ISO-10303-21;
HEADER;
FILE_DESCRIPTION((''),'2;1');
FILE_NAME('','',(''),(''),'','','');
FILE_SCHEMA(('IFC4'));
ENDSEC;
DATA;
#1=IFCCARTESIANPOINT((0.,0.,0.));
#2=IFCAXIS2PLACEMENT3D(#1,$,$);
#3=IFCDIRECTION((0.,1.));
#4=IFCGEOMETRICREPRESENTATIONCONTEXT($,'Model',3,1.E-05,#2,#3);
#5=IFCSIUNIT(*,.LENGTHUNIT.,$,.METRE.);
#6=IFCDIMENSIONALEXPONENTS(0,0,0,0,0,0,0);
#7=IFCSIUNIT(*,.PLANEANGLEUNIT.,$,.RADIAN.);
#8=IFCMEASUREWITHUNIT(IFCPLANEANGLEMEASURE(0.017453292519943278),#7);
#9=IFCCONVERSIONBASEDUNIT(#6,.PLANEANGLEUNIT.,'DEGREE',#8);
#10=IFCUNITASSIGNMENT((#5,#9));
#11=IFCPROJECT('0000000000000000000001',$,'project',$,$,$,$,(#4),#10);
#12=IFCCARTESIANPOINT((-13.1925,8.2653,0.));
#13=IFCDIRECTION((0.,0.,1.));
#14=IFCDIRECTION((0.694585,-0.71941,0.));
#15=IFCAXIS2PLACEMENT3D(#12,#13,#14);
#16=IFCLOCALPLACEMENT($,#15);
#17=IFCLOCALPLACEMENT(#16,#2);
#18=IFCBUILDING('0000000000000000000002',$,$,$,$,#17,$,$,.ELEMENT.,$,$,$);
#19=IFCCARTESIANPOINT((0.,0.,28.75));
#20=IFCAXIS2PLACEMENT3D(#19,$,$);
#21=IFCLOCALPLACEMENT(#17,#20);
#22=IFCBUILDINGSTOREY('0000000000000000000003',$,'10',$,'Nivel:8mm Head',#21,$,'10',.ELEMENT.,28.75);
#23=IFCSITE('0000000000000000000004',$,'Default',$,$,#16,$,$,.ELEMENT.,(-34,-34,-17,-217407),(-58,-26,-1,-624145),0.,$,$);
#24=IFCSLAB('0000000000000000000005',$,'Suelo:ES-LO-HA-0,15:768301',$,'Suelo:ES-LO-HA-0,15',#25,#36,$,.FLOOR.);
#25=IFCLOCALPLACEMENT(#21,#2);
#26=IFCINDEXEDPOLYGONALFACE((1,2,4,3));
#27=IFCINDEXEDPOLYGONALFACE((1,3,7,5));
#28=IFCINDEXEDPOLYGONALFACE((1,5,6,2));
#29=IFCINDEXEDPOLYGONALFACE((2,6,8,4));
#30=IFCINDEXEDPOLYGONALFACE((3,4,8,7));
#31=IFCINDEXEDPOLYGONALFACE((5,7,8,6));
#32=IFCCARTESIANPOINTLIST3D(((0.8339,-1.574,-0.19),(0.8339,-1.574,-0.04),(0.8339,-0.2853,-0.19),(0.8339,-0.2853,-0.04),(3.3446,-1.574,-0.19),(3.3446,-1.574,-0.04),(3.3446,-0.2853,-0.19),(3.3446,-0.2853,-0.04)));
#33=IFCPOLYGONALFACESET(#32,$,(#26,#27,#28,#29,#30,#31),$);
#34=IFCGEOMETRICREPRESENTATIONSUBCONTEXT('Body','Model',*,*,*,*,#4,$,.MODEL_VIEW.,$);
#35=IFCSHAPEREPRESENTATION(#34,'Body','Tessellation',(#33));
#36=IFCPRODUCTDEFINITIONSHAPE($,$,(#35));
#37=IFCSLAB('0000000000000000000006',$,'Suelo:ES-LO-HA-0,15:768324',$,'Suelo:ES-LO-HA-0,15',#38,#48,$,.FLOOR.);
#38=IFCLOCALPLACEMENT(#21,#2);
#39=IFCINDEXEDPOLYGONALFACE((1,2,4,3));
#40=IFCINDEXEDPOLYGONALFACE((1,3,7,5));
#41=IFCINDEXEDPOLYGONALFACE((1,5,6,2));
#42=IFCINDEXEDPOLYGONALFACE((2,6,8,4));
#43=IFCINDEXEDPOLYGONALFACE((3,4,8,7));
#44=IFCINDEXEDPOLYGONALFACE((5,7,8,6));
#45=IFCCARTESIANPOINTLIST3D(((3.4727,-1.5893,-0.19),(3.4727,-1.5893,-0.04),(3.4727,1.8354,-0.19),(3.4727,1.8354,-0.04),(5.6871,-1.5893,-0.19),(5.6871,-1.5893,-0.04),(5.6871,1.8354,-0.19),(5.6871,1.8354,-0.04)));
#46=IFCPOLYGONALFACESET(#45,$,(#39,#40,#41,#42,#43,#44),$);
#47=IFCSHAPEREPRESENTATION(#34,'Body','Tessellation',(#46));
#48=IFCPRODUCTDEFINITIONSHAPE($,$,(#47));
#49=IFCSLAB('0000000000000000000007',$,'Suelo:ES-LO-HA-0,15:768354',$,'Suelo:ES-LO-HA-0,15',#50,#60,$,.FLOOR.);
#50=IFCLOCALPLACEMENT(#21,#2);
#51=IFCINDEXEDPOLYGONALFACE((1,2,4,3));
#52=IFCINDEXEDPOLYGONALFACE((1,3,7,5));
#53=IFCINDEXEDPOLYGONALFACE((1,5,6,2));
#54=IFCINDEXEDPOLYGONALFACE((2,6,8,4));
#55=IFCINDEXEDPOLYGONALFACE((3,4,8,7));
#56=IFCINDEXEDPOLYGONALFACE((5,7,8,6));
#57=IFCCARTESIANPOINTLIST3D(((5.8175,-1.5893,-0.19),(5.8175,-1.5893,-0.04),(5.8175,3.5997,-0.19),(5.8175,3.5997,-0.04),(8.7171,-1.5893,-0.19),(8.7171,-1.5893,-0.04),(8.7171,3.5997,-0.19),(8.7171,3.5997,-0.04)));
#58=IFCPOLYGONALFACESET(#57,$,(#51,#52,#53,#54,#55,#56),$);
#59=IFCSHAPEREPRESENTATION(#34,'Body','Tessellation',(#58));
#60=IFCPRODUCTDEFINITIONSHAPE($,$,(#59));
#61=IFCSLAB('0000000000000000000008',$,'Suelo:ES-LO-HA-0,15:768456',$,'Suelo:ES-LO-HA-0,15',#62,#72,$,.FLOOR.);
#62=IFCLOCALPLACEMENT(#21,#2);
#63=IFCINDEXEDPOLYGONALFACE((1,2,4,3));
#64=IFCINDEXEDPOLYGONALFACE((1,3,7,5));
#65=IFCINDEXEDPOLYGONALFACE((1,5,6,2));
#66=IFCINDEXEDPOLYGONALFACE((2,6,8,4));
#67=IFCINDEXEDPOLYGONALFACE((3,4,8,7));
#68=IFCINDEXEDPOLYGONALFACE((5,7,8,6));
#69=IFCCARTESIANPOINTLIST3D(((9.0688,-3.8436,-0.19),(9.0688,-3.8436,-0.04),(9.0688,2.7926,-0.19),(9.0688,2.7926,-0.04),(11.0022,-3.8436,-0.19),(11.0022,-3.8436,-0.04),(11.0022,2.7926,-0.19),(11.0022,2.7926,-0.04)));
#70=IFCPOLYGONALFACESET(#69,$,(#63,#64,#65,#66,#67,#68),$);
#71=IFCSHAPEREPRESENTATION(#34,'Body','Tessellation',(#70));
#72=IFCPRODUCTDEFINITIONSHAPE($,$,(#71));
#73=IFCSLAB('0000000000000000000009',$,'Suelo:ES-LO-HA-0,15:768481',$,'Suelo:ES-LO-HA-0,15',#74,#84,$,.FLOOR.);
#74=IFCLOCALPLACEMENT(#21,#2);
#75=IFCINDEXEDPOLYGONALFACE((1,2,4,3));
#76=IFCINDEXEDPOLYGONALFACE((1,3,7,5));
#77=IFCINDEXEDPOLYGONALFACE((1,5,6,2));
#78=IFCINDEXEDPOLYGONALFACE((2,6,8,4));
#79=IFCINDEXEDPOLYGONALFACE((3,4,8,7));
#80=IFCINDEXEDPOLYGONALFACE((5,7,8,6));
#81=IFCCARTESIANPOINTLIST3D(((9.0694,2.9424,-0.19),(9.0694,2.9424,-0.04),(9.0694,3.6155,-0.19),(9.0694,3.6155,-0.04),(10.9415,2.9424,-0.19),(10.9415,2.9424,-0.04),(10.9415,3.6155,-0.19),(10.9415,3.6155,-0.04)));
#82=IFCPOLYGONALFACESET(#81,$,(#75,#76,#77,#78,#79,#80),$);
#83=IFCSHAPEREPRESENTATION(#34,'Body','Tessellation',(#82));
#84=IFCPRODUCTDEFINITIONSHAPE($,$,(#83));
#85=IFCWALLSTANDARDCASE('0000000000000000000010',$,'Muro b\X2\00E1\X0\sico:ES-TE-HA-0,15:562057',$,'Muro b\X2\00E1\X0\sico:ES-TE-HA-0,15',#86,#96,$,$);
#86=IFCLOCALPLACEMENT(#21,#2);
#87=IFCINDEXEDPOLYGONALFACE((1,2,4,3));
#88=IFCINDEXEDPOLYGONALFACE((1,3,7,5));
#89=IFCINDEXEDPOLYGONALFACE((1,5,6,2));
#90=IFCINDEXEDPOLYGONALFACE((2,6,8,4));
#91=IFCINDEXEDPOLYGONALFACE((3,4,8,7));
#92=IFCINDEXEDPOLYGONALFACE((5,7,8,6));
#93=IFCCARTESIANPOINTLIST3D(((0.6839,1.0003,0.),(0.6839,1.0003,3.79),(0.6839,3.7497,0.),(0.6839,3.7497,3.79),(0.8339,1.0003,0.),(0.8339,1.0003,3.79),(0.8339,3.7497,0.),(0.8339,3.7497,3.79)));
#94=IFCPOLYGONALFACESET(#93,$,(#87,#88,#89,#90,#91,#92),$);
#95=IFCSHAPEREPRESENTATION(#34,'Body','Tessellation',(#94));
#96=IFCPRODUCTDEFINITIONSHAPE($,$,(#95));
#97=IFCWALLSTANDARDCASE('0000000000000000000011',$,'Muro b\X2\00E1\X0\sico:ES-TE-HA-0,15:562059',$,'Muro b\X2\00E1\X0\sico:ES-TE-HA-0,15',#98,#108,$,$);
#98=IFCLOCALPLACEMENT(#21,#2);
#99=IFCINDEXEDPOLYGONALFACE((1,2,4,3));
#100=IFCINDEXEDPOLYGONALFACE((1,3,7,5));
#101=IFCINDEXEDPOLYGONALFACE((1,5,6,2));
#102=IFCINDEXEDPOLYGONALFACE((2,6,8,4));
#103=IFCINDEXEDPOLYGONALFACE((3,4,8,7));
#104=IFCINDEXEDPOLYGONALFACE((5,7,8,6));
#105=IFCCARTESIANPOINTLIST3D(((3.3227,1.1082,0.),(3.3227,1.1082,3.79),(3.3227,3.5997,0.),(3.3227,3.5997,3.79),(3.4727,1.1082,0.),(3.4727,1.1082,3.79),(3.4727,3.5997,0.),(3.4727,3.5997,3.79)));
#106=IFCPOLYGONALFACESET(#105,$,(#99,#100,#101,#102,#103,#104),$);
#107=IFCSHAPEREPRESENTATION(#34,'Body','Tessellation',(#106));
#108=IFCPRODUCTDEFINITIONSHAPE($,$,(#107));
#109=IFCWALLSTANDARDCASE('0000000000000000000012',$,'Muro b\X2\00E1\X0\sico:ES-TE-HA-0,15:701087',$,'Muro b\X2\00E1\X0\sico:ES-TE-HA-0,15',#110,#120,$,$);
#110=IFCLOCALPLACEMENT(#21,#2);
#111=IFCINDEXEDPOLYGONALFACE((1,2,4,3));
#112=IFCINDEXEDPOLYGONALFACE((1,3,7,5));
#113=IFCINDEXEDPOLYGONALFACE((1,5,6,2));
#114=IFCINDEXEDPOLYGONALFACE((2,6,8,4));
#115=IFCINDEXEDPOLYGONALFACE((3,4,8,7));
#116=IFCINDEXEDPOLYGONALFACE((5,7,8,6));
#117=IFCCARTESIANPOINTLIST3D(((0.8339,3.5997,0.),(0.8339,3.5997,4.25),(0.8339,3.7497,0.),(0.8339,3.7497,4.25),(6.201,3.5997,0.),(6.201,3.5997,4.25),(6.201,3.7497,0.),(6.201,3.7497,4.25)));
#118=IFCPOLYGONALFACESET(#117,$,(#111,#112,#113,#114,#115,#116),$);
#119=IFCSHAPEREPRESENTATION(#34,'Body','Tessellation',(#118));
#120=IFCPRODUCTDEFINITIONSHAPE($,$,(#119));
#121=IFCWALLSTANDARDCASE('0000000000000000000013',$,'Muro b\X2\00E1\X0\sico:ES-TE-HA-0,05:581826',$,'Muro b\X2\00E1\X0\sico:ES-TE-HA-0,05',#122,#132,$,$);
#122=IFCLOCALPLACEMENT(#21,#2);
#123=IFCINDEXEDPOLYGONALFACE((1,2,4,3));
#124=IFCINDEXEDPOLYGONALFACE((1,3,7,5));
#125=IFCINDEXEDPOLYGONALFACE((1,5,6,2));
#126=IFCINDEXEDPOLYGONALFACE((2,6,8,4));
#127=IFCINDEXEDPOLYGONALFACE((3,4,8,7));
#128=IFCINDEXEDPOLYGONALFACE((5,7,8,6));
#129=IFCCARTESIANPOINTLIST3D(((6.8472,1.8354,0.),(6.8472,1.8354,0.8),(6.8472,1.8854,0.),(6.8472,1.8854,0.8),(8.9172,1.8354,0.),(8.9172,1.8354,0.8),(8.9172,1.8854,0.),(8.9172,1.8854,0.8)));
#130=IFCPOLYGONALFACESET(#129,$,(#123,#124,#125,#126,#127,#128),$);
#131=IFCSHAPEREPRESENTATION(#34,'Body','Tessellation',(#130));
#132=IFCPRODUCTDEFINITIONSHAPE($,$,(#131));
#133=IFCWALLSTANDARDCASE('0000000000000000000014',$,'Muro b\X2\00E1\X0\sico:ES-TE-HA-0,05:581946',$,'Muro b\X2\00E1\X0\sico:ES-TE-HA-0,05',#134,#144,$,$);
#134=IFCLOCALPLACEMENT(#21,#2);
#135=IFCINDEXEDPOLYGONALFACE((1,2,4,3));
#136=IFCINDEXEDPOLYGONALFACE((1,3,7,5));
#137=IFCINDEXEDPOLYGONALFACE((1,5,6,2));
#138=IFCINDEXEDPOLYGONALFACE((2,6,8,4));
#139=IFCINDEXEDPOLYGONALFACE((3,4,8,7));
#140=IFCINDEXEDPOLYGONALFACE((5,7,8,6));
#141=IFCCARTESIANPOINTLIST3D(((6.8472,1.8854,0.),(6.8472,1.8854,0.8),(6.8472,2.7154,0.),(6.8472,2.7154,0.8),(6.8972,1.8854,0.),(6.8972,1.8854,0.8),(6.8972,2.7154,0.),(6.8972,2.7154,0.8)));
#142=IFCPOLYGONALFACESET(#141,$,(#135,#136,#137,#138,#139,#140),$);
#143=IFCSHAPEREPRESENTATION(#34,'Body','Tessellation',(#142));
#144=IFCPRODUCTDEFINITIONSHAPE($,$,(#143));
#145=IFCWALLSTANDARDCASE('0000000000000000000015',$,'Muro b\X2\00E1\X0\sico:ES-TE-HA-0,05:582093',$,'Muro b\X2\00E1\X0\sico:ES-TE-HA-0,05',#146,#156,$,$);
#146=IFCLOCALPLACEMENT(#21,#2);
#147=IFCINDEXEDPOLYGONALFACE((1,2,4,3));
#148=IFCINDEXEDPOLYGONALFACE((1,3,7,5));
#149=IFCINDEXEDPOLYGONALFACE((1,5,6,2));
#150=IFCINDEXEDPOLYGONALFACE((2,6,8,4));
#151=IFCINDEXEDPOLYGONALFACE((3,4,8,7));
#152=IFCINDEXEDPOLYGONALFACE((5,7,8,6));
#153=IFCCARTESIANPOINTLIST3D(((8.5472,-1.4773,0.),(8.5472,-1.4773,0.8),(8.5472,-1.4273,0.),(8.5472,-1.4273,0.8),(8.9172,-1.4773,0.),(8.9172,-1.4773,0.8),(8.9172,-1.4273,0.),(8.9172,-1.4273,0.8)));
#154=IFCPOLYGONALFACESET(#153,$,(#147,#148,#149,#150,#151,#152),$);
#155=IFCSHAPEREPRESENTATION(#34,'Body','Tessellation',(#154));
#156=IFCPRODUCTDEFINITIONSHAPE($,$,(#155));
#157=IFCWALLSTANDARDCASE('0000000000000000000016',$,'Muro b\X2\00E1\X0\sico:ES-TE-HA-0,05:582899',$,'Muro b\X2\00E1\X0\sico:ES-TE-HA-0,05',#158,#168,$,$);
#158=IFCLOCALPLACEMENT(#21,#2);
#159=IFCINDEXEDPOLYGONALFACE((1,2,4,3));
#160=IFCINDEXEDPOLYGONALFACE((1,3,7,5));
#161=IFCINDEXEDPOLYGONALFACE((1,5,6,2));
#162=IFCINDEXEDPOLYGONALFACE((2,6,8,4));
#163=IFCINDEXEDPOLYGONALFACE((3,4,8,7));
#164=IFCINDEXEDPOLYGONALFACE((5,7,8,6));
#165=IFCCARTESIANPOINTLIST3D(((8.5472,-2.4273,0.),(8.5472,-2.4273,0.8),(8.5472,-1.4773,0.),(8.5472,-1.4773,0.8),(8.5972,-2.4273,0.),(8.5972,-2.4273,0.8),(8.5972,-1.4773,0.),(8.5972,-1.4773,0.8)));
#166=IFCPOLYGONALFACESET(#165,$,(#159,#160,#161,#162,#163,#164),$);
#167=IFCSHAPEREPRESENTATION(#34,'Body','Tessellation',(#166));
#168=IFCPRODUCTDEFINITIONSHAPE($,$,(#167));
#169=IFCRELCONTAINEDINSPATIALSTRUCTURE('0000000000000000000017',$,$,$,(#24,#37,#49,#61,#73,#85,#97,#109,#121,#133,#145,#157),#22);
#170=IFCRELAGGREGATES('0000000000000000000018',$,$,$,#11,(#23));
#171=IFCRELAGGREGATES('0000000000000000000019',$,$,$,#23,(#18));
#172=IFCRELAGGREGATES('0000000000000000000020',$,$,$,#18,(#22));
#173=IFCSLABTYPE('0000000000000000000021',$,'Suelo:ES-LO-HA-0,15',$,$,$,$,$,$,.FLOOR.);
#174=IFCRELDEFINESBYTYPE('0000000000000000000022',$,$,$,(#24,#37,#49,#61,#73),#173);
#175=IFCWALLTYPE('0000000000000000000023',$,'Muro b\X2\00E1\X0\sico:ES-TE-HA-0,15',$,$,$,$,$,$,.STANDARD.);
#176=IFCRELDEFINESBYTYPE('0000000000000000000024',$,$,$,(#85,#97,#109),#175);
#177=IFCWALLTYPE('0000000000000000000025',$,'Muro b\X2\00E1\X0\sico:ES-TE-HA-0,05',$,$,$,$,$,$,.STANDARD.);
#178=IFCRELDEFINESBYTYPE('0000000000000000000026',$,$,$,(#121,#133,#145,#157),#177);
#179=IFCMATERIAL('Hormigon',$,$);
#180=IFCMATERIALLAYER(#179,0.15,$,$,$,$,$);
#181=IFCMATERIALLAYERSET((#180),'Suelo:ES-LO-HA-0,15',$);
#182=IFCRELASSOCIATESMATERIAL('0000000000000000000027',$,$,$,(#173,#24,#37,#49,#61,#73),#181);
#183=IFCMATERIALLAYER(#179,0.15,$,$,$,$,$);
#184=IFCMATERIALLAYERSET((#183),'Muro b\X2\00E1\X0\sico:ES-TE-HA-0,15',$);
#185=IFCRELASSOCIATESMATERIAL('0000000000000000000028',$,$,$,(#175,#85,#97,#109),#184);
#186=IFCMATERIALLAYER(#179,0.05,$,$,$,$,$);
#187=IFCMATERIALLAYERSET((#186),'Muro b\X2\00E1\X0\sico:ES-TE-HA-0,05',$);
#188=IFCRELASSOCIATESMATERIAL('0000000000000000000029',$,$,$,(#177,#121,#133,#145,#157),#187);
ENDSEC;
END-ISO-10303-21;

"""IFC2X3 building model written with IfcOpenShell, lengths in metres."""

from ifc_helpers import new_model, entity, si_unit, converted_unit, direction, frame, frame_2d, origin, origin_2d_with_axis, place, context, subcontext, project, spatial, rectangle, extrude, material, layer, layer_set, layer_usage, type_object, element, save


model = new_model("IFC2X3")

# Units and contexts
model_context = context("Model", 3, precision=1e-05, world=origin(), true_north=direction((0.0, 1.0)))
body_context = subcontext(model_context, "Body", "Model", "MODEL_VIEW")
ifc_project = project(units=[si_unit("LENGTHUNIT", "METRE"), converted_unit("PLANEANGLEUNIT", "DEGREE", entity("IfcPlaneAngleMeasure", 0.017453292519943278), si_unit("PLANEANGLEUNIT", "RADIAN"), dimensions=[0, 0, 0, 0, 0, 0, 0])], contexts=[model_context])

# Site, building, storey
site_placement = place(None, frame((-13.1925, 8.2653, 0.0), z_axis=(0.0, 0.0, 1.0), x_axis=(0.694585, -0.71941, 0.0)))
site = spatial("IfcSite", under=ifc_project, at=site_placement, Name="Default", CompositionType="ELEMENT", RefLatitude=(-34, -34, -17, -217407), RefLongitude=(-58, -26, -1, -624145), RefElevation=0.0)
building_placement = place(site_placement, origin())
building = spatial("IfcBuilding", under=site, at=building_placement, CompositionType="ELEMENT")
storey_placement = place(building_placement, frame((0.0, 0.0, 28.75)))
storey = spatial("IfcBuildingStorey", under=building, at=storey_placement, Name="10", ObjectType="Nivel:8mm Head", LongName="10", CompositionType="ELEMENT", Elevation=28.75)

# Slabs
ifc_material_1 = material(Name="Hormigon")
ifc_layer_1 = layer(ifc_material_1, 0.15)
ifc_layer_set_1 = layer_set([ifc_layer_1], Name="Suelo:ES-LO-HA-0,15")
slab_type = type_object("IfcSlabType", Name="Suelo:ES-LO-HA-0,15", PredefinedType="FLOOR", material=ifc_layer_set_1)
ifc_layer_usage_1 = layer_usage(ifc_layer_set_1, "AXIS3", "POSITIVE", 0.0)
slab_1_placement = place(storey_placement, origin())
element("IfcSlab", 1, at=slab_1_placement, inside=storey, type_object=slab_type, material=ifc_layer_usage_1, Name="Suelo:ES-LO-HA-0,15:768301", ObjectType="Suelo:ES-LO-HA-0,15", PredefinedType="FLOOR", context=body_context, shape_type="SweptSolid", body=[
    extrude(rectangle(XDim=1.2887, YDim=2.5106, at=frame_2d((0.0, 0.0), x_axis=(1.0, 0.0))), frame((2.0893, -0.9297, -0.04), z_axis=(0.0, 0.0, -1.0), x_axis=(0.0, 1.0, 0.0)), (0.0, 0.0, 1.0), 0.15),
])
ifc_layer_usage_2 = layer_usage(ifc_layer_set_1, "AXIS3", "POSITIVE", 0.0)
slab_2_placement = place(storey_placement, origin())
element("IfcSlab", 2, at=slab_2_placement, inside=storey, type_object=slab_type, material=ifc_layer_usage_2, Name="Suelo:ES-LO-HA-0,15:768324", ObjectType="Suelo:ES-LO-HA-0,15", PredefinedType="FLOOR", context=body_context, shape_type="SweptSolid", body=[
    extrude(rectangle(XDim=3.4247, YDim=2.2143, at=frame_2d((0.0, 0.0), x_axis=(1.0, 0.0))), frame((4.5799, 0.1231, -0.04), z_axis=(0.0, 0.0, -1.0), x_axis=(0.0, 1.0, 0.0)), (0.0, 0.0, 1.0), 0.15),
])
ifc_layer_usage_3 = layer_usage(ifc_layer_set_1, "AXIS3", "POSITIVE", 0.0)
slab_3_placement = place(storey_placement, origin())
element("IfcSlab", 3, at=slab_3_placement, inside=storey, type_object=slab_type, material=ifc_layer_usage_3, Name="Suelo:ES-LO-HA-0,15:768354", ObjectType="Suelo:ES-LO-HA-0,15", PredefinedType="FLOOR", context=body_context, shape_type="SweptSolid", body=[
    extrude(rectangle(XDim=5.1889, YDim=2.8995, at=frame_2d((0.0, 0.0), x_axis=(1.0, 0.0))), frame((7.2673, 1.0052, -0.04), z_axis=(0.0, 0.0, -1.0), x_axis=(0.0, 1.0, 0.0)), (0.0, 0.0, 1.0), 0.15),
])
ifc_layer_usage_4 = layer_usage(ifc_layer_set_1, "AXIS3", "POSITIVE", 0.0)
slab_4_placement = place(storey_placement, origin())
element("IfcSlab", 4, at=slab_4_placement, inside=storey, type_object=slab_type, material=ifc_layer_usage_4, Name="Suelo:ES-LO-HA-0,15:768456", ObjectType="Suelo:ES-LO-HA-0,15", PredefinedType="FLOOR", context=body_context, shape_type="SweptSolid", body=[
    extrude(rectangle(XDim=6.6361, YDim=1.9334, at=origin_2d_with_axis()), frame((10.0355, -0.5255, -0.04), z_axis=(0.0, 0.0, -1.0), x_axis=(0.0, 1.0, 0.0)), (0.0, 0.0, 1.0), 0.15),
])
ifc_layer_usage_5 = layer_usage(ifc_layer_set_1, "AXIS3", "POSITIVE", 0.0)
slab_5_placement = place(storey_placement, origin())
element("IfcSlab", 5, at=slab_5_placement, inside=storey, type_object=slab_type, material=ifc_layer_usage_5, Name="Suelo:ES-LO-HA-0,15:768481", ObjectType="Suelo:ES-LO-HA-0,15", PredefinedType="FLOOR", context=body_context, shape_type="SweptSolid", body=[
    extrude(rectangle(XDim=0.6731, YDim=1.872, at=origin_2d_with_axis()), frame((10.0055, 3.2789, -0.04), z_axis=(0.0, 0.0, -1.0), x_axis=(0.0, 1.0, 0.0)), (0.0, 0.0, 1.0), 0.15),
])

# Walls
ifc_layer_2 = layer(ifc_material_1, 0.15)
ifc_layer_set_2 = layer_set([ifc_layer_2], Name="Muro básico:ES-TE-HA-0,15")
ifc_layer_usage_6 = layer_usage(ifc_layer_set_2, "AXIS2", "NEGATIVE", 0.075)
wall_type_1 = type_object("IfcWallType", Name="Muro básico:ES-TE-HA-0,15", PredefinedType="STANDARD", material=ifc_layer_set_2)
wall_1_placement = place(storey_placement, frame((0.7589, 1.0003, 0.0), z_axis=(0.0, 0.0, 1.0), x_axis=(0.0, 1.0, 0.0)))
element("IfcWallStandardCase", 6, at=wall_1_placement, inside=storey, type_object=wall_type_1, material=ifc_layer_usage_6, Name="Muro básico:ES-TE-HA-0,15:562057", ObjectType="Muro básico:ES-TE-HA-0,15", context=body_context, shape_type="SweptSolid", body=[
    extrude(rectangle(XDim=2.7494, YDim=0.15, at=frame_2d((1.3747, 0.0), x_axis=(-1.0, 0.0))), origin(), (0.0, 0.0, 1.0), 3.79),
])
ifc_layer_usage_7 = layer_usage(ifc_layer_set_2, "AXIS2", "NEGATIVE", 0.075)
wall_2_placement = place(storey_placement, frame((3.3977, 3.5997, 0.0), z_axis=(0.0, 0.0, 1.0), x_axis=(0.0, -1.0, 0.0)))
element("IfcWallStandardCase", 7, at=wall_2_placement, inside=storey, type_object=wall_type_1, material=ifc_layer_usage_7, Name="Muro básico:ES-TE-HA-0,15:562059", ObjectType="Muro básico:ES-TE-HA-0,15", context=body_context, shape_type="SweptSolid", body=[
    extrude(rectangle(XDim=2.4914, YDim=0.15, at=frame_2d((1.2457, 0.0), x_axis=(-1.0, 0.0))), origin(), (0.0, 0.0, 1.0), 3.79),
])
ifc_layer_usage_8 = layer_usage(ifc_layer_set_2, "AXIS2", "NEGATIVE", 0.075)
wall_3_placement = place(storey_placement, frame((0.8339, 3.6747, 0.0)))
element("IfcWallStandardCase", 8, at=wall_3_placement, inside=storey, type_object=wall_type_1, material=ifc_layer_usage_8, Name="Muro básico:ES-TE-HA-0,15:701087", ObjectType="Muro básico:ES-TE-HA-0,15", context=body_context, shape_type="SweptSolid", body=[
    extrude(rectangle(XDim=5.367, YDim=0.15, at=frame_2d((2.6835, 0.0), x_axis=(-1.0, 0.0))), origin(), (0.0, 0.0, 1.0), 4.25),
])
ifc_layer_3 = layer(ifc_material_1, 0.05)
ifc_layer_set_3 = layer_set([ifc_layer_3], Name="Muro básico:ES-TE-HA-0,05")
ifc_layer_usage_9 = layer_usage(ifc_layer_set_3, "AXIS2", "POSITIVE", -0.025)
wall_type_2 = type_object("IfcWallType", Name="Muro básico:ES-TE-HA-0,05", PredefinedType="STANDARD", material=ifc_layer_set_3)
wall_4_placement = place(storey_placement, frame((6.8472, 1.8604, 0.0)))
element("IfcWallStandardCase", 9, at=wall_4_placement, inside=storey, type_object=wall_type_2, material=ifc_layer_usage_9, Name="Muro básico:ES-TE-HA-0,05:581826", ObjectType="Muro básico:ES-TE-HA-0,05", context=body_context, shape_type="SweptSolid", body=[
    extrude(rectangle(XDim=2.07, YDim=0.05, at=frame_2d((1.035, 0.0), x_axis=(-1.0, 0.0))), origin(), (0.0, 0.0, 1.0), 0.8),
])
ifc_layer_usage_10 = layer_usage(ifc_layer_set_3, "AXIS2", "NEGATIVE", 0.025)
wall_5_placement = place(storey_placement, frame((6.8722, 1.8854, 0.0), z_axis=(0.0, 0.0, 1.0), x_axis=(0.0, 1.0, 0.0)))
element("IfcWallStandardCase", 10, at=wall_5_placement, inside=storey, type_object=wall_type_2, material=ifc_layer_usage_10, Name="Muro básico:ES-TE-HA-0,05:581946", ObjectType="Muro básico:ES-TE-HA-0,05", context=body_context, shape_type="SweptSolid", body=[
    extrude(rectangle(XDim=0.83, YDim=0.05, at=frame_2d((0.415, 0.0), x_axis=(-1.0, 0.0))), origin(), (0.0, 0.0, 1.0), 0.8),
])
ifc_layer_usage_11 = layer_usage(ifc_layer_set_3, "AXIS2", "NEGATIVE", 0.025)
wall_6_placement = place(storey_placement, frame((8.5472, -1.4523, 0.0)))
element("IfcWallStandardCase", 11, at=wall_6_placement, inside=storey, type_object=wall_type_2, material=ifc_layer_usage_11, Name="Muro básico:ES-TE-HA-0,05:582093", ObjectType="Muro básico:ES-TE-HA-0,05", context=body_context, shape_type="SweptSolid", body=[
    extrude(rectangle(XDim=0.37, YDim=0.05, at=frame_2d((0.185, 0.0), x_axis=(-1.0, 0.0))), origin(), (0.0, 0.0, 1.0), 0.8),
])
ifc_layer_usage_12 = layer_usage(ifc_layer_set_3, "AXIS2", "POSITIVE", -0.025)
wall_7_placement = place(storey_placement, frame((8.5722, -1.4773, 0.0), z_axis=(0.0, 0.0, 1.0), x_axis=(0.0, -1.0, 0.0)))
element("IfcWallStandardCase", 12, at=wall_7_placement, inside=storey, type_object=wall_type_2, material=ifc_layer_usage_12, Name="Muro básico:ES-TE-HA-0,05:582899", ObjectType="Muro básico:ES-TE-HA-0,05", context=body_context, shape_type="SweptSolid", body=[
    extrude(rectangle(XDim=0.95, YDim=0.05, at=frame_2d((0.475, 0.0), x_axis=(-1.0, 0.0))), origin(), (0.0, 0.0, 1.0), 0.8),
])

save(model, "model.ifc")
